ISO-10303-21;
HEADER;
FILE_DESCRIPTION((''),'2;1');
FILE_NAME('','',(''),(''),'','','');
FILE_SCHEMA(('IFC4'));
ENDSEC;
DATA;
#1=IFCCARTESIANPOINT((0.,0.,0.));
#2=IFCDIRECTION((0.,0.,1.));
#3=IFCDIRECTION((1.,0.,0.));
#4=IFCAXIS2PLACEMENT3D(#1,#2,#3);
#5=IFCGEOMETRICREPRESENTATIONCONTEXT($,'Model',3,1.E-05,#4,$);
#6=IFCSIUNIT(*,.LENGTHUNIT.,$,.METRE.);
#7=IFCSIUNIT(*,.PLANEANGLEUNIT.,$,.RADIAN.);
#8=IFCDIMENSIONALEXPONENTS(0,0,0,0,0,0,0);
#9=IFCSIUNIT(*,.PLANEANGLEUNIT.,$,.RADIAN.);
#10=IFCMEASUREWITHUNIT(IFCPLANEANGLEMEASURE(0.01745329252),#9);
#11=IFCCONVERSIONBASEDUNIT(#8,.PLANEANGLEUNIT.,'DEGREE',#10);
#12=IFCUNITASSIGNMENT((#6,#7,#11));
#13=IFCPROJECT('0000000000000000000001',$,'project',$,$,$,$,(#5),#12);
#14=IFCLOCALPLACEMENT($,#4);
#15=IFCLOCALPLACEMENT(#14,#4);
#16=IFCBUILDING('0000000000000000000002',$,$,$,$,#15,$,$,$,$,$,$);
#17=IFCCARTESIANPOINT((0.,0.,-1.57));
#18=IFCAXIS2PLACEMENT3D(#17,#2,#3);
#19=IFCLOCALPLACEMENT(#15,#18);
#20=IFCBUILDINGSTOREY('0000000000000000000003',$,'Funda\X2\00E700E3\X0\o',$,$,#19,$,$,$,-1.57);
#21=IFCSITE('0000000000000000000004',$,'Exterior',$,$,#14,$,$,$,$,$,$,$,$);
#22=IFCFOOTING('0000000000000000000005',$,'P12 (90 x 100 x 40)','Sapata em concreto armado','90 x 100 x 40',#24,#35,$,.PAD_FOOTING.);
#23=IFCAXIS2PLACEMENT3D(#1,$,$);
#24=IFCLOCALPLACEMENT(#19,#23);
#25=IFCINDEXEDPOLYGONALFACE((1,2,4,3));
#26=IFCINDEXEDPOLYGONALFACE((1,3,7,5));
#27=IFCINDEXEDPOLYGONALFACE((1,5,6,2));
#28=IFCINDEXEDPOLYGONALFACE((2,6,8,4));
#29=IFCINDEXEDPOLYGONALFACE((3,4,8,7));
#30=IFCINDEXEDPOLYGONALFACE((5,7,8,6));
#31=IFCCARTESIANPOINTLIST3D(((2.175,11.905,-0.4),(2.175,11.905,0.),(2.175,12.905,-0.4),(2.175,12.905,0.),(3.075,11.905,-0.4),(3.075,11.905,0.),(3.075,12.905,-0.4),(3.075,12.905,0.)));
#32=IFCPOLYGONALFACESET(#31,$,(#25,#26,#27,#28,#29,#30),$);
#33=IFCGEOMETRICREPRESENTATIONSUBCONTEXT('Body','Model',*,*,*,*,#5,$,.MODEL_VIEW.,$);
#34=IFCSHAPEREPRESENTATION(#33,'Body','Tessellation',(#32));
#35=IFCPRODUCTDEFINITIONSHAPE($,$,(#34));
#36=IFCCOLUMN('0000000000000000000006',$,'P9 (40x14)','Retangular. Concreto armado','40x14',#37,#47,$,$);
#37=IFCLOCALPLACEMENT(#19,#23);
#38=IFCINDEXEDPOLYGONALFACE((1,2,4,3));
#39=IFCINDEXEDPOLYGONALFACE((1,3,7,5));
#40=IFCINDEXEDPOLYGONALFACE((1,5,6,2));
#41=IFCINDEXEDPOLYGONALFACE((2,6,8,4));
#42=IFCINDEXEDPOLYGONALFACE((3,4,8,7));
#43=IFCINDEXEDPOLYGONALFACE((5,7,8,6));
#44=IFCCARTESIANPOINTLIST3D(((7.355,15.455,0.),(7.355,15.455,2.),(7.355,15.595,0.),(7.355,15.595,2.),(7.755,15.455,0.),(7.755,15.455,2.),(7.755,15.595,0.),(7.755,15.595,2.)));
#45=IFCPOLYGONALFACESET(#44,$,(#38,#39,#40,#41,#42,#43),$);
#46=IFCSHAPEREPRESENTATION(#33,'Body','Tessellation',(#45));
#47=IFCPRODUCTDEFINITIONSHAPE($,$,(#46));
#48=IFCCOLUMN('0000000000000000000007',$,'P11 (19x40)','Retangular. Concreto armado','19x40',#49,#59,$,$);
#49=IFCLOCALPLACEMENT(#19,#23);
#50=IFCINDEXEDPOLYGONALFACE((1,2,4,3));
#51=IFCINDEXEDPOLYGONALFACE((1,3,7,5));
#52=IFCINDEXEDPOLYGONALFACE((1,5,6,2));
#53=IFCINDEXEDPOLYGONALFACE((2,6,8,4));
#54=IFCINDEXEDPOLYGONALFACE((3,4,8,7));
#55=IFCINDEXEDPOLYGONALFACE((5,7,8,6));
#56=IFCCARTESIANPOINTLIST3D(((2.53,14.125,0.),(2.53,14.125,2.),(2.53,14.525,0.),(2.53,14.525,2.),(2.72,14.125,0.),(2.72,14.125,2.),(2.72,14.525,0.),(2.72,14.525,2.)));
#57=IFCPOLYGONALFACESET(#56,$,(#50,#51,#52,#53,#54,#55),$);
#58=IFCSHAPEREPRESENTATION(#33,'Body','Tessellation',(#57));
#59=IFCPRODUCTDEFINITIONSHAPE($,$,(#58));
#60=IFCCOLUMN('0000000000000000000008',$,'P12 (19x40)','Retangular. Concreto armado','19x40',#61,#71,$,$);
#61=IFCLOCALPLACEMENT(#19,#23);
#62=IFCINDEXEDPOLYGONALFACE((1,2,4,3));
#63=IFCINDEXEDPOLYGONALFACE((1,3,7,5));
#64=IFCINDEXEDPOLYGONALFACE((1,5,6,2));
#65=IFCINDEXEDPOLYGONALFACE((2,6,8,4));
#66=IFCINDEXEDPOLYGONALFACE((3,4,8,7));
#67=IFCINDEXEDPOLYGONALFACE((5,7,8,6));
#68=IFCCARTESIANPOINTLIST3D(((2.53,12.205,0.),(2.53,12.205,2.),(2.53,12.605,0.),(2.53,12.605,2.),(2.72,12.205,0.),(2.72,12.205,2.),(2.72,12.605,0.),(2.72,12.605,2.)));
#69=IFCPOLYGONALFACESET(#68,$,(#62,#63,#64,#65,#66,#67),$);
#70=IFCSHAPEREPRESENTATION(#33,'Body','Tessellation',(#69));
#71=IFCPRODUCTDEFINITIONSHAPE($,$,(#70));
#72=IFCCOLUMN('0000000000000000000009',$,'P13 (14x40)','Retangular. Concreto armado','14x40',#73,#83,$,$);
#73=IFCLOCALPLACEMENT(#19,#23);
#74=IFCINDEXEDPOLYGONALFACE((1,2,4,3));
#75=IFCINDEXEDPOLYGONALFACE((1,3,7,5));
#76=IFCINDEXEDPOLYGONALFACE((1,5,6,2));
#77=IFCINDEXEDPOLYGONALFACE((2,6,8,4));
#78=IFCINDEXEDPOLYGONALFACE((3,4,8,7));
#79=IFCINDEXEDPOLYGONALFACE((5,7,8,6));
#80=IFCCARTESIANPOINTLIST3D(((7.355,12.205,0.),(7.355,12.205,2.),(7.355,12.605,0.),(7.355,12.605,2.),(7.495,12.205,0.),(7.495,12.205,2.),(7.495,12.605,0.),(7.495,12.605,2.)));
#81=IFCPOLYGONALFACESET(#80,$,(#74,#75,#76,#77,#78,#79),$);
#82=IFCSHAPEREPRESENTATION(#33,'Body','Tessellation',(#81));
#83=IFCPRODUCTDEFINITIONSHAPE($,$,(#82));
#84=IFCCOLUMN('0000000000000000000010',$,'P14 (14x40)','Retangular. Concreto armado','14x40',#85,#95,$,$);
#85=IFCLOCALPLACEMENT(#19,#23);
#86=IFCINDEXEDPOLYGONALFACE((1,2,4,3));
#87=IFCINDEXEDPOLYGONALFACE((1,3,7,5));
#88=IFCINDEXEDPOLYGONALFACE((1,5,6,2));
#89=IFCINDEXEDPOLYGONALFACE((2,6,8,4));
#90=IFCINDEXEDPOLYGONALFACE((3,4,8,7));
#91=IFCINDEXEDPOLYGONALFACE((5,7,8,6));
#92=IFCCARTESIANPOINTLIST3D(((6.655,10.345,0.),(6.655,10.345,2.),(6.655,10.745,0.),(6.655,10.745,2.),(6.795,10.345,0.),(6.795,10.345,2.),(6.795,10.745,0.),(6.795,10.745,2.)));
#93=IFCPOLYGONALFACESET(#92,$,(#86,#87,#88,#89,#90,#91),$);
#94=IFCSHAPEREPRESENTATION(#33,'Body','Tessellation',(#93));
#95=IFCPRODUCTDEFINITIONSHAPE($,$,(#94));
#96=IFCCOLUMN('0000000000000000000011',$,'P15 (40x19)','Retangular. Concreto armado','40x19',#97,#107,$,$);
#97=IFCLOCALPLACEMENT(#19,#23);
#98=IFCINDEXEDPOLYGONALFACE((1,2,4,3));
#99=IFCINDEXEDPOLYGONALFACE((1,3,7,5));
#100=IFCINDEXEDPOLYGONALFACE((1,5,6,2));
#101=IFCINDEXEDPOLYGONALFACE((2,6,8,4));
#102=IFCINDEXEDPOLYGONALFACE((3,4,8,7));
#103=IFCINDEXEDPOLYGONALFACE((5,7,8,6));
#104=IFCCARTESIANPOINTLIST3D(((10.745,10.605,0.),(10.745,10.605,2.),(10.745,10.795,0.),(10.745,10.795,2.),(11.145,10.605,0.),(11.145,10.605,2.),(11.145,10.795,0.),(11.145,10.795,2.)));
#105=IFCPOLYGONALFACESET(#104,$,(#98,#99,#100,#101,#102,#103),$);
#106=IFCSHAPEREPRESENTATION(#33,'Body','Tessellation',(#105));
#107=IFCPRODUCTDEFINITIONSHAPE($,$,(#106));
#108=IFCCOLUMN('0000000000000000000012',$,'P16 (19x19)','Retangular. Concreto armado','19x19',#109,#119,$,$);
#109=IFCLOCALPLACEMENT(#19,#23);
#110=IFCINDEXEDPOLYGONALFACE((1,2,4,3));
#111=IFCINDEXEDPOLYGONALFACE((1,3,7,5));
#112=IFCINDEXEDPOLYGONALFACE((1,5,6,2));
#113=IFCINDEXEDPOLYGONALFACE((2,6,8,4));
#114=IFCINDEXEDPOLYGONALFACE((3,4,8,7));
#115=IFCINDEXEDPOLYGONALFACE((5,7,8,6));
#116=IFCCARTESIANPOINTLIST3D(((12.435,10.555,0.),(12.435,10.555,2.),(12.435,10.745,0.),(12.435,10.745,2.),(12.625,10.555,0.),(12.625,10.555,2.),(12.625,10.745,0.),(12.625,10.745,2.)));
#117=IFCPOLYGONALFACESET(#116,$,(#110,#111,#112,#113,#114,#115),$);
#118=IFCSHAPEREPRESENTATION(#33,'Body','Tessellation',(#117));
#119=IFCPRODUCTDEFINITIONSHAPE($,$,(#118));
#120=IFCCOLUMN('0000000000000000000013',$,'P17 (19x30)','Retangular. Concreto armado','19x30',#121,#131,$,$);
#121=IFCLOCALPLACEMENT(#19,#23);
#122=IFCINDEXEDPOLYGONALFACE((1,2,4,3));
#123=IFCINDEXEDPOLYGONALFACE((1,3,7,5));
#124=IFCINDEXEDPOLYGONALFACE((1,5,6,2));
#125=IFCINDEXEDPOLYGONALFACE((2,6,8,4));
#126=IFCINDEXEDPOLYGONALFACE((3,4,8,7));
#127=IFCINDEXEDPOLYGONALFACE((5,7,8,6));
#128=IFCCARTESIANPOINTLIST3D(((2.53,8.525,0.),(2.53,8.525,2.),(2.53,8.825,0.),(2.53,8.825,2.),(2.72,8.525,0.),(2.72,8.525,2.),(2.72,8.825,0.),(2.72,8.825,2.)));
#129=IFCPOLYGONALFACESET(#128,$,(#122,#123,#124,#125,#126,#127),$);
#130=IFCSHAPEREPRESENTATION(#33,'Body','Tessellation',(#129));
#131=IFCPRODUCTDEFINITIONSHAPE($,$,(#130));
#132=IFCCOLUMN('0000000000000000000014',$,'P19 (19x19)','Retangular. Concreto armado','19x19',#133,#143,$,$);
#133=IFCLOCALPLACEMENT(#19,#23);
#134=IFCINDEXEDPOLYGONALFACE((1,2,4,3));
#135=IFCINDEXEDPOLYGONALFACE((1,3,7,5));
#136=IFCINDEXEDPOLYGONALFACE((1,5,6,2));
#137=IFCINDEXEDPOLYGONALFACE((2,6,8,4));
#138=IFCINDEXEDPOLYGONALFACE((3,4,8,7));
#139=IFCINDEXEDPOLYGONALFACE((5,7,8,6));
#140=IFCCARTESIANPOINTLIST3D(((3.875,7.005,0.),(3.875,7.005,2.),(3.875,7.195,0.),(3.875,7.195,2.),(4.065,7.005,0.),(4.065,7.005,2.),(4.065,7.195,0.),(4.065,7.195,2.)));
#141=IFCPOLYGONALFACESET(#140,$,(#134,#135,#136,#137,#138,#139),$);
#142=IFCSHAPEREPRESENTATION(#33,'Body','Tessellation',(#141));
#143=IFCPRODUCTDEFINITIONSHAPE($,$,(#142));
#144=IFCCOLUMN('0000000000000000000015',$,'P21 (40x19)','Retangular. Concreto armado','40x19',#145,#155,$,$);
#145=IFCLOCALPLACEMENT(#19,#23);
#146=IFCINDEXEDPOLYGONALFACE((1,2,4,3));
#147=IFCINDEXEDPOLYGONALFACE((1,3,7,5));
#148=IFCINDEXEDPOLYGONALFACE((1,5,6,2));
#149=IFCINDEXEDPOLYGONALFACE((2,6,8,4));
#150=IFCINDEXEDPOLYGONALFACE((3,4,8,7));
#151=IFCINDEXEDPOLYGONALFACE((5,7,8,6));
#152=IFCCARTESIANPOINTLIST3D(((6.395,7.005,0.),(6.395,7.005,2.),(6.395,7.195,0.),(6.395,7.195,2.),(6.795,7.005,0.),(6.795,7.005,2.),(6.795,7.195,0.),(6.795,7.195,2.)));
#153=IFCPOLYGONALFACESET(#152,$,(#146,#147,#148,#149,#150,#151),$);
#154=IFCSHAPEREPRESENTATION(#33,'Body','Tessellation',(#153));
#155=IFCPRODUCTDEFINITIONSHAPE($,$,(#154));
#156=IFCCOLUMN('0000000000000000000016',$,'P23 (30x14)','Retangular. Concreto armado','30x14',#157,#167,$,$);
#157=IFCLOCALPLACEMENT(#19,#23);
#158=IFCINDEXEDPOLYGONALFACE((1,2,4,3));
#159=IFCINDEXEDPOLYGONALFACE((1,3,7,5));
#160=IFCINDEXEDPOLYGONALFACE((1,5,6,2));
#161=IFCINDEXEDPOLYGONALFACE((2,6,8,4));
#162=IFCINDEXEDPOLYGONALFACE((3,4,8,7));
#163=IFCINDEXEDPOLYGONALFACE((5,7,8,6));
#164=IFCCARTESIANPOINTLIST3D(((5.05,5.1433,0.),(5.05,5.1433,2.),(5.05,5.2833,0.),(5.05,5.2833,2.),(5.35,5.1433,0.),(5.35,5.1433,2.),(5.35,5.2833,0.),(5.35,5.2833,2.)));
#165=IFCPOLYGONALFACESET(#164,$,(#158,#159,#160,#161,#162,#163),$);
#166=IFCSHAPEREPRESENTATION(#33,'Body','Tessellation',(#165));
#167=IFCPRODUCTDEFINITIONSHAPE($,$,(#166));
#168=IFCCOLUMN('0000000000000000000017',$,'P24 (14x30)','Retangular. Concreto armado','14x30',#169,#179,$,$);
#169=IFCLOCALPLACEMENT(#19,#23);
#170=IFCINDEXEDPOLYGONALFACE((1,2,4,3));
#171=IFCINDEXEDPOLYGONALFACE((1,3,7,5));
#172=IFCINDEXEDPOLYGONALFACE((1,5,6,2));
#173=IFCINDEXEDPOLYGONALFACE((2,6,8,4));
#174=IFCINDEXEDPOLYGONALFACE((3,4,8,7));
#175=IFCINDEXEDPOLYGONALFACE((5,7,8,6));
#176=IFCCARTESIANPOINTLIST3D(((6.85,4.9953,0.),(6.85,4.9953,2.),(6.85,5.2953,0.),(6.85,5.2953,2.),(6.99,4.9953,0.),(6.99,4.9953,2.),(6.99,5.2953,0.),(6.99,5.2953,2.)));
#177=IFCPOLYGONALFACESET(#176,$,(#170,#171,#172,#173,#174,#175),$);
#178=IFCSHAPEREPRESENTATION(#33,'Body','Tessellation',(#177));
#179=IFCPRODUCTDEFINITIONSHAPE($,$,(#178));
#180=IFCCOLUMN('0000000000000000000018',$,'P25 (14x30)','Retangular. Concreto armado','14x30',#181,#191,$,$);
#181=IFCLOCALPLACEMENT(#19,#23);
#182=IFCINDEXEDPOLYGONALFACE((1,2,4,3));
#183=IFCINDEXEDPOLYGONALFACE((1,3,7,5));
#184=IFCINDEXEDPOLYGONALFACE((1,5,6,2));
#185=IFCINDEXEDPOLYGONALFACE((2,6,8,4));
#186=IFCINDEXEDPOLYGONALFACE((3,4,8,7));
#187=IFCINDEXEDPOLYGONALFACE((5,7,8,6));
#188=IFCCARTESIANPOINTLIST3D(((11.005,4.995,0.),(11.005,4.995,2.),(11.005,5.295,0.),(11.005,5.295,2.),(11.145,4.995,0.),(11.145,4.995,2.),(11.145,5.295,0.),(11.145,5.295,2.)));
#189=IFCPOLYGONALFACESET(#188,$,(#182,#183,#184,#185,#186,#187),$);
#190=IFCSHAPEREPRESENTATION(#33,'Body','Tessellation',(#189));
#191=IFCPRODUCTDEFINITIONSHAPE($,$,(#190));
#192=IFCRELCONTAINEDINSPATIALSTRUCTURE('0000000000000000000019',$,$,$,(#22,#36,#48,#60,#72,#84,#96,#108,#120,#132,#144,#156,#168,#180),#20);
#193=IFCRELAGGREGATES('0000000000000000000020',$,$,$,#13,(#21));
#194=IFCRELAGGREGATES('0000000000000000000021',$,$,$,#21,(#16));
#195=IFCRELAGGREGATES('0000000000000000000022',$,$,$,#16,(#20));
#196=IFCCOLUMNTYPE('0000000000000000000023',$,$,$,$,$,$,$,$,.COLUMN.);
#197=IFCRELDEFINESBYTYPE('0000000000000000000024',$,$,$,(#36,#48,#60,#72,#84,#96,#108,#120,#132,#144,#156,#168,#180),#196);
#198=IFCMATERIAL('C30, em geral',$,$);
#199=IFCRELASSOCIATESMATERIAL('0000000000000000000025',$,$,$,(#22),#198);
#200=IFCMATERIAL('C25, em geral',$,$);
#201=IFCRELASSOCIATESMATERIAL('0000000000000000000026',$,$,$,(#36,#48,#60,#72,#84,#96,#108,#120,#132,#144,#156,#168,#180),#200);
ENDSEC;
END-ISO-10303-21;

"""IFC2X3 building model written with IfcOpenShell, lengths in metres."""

from ifc_helpers import new_model, entity, si_unit, converted_unit, frame, frame_2d, origin_with_axes, origin_2d_with_axis, place, context, subcontext, project, spatial, rectangle, extrude, material, type_object, element, save


model = new_model("IFC2X3")

# Units and contexts
model_context = context("Model", 3, precision=1e-05, world=origin_with_axes())
body_context = subcontext(model_context, "Body", "Model", "MODEL_VIEW")
ifc_project = project(units=[si_unit("LENGTHUNIT", "METRE"), si_unit("PLANEANGLEUNIT", "RADIAN"), converted_unit("PLANEANGLEUNIT", "DEGREE", entity("IfcPlaneAngleMeasure", 0.01745329252), si_unit("PLANEANGLEUNIT", "RADIAN"), dimensions=[0, 0, 0, 0, 0, 0, 0])], contexts=[model_context])

# Site, building, storey
site_placement = place(None, origin_with_axes())
site = spatial("IfcSite", under=ifc_project, at=site_placement, Name="Exterior")
building_placement = place(site_placement, origin_with_axes())
building = spatial("IfcBuilding", under=site, at=building_placement)
storey_placement = place(building_placement, frame((0.0, 0.0, -1.57), z_axis=(0.0, 0.0, 1.0), x_axis=(1.0, 0.0, 0.0)))
storey = spatial("IfcBuildingStorey", under=building, at=storey_placement, Name="Fundação", Elevation=-1.57)

# Footing
ifc_material_1 = material(Name="C30, em geral")
footing_1_placement = place(storey_placement, frame((2.625, 12.405, -0.4), z_axis=(0.0, 0.0, 1.0), x_axis=(1.0, 0.0, 0.0)))
element("IfcFooting", 1, at=footing_1_placement, inside=storey, material=ifc_material_1, Name="P12 (90 x 100 x 40)", Description="Sapata em concreto armado", ObjectType="90 x 100 x 40", PredefinedType="PAD_FOOTING", context=body_context, shape_type="SweptSolid", body=[
    extrude(rectangle(XDim=0.9, YDim=1.0, at=origin_2d_with_axis()), origin_with_axes(), (0.0, 0.0, 1.0), 0.4),
])

# Columns
ifc_material_2 = material(Name="C25, em geral")
column_type = type_object("IfcColumnType", PredefinedType="COLUMN")
column_1_placement = place(storey_placement, frame((7.355, 15.455, 0.0), z_axis=(0.0, 0.0, 1.0), x_axis=(1.0, 0.0, 0.0)))
element("IfcColumn", 2, at=column_1_placement, inside=storey, type_object=column_type, material=ifc_material_2, Name="P9 (40x14)", Description="Retangular. Concreto armado", ObjectType="40x14", context=body_context, shape_type="SweptSolid", body=[
    extrude(rectangle(XDim=0.4, YDim=0.14, at=frame_2d((0.2, 0.07), x_axis=(1.0, 0.0))), origin_with_axes(), (0.0, 0.0, 1.0), 2.0),
])
column_2_placement = place(storey_placement, frame((2.53, 14.525, 0.0), z_axis=(0.0, 0.0, 1.0), x_axis=(1.0, 0.0, 0.0)))
element("IfcColumn", 3, at=column_2_placement, inside=storey, type_object=column_type, material=ifc_material_2, Name="P11 (19x40)", Description="Retangular. Concreto armado", ObjectType="19x40", context=body_context, shape_type="SweptSolid", body=[
    extrude(rectangle(XDim=0.19, YDim=0.4, at=frame_2d((0.095, -0.2), x_axis=(1.0, 0.0))), origin_with_axes(), (0.0, 0.0, 1.0), 2.0),
])
column_3_placement = place(storey_placement, frame((2.53, 12.205, 0.0), z_axis=(0.0, 0.0, 1.0), x_axis=(1.0, 0.0, 0.0)))
element("IfcColumn", 4, at=column_3_placement, inside=storey, type_object=column_type, material=ifc_material_2, Name="P12 (19x40)", Description="Retangular. Concreto armado", ObjectType="19x40", context=body_context, shape_type="SweptSolid", body=[
    extrude(rectangle(XDim=0.19, YDim=0.4, at=frame_2d((0.095, 0.2), x_axis=(1.0, 0.0))), origin_with_axes(), (0.0, 0.0, 1.0), 2.0),
])
column_4_placement = place(storey_placement, frame((7.495, 12.205, 0.0), z_axis=(0.0, 0.0, 1.0), x_axis=(1.0, 0.0, 0.0)))
element("IfcColumn", 5, at=column_4_placement, inside=storey, type_object=column_type, material=ifc_material_2, Name="P13 (14x40)", Description="Retangular. Concreto armado", ObjectType="14x40", context=body_context, shape_type="SweptSolid", body=[
    extrude(rectangle(XDim=0.14, YDim=0.4, at=frame_2d((-0.07, 0.2), x_axis=(1.0, 0.0))), origin_with_axes(), (0.0, 0.0, 1.0), 2.0),
])
column_5_placement = place(storey_placement, frame((6.655, 10.745, 0.0), z_axis=(0.0, 0.0, 1.0), x_axis=(1.0, 0.0, 0.0)))
element("IfcColumn", 6, at=column_5_placement, inside=storey, type_object=column_type, material=ifc_material_2, Name="P14 (14x40)", Description="Retangular. Concreto armado", ObjectType="14x40", context=body_context, shape_type="SweptSolid", body=[
    extrude(rectangle(XDim=0.14, YDim=0.4, at=frame_2d((0.07, -0.2), x_axis=(1.0, 0.0))), origin_with_axes(), (0.0, 0.0, 1.0), 2.0),
])
column_6_placement = place(storey_placement, frame((11.145, 10.605, 0.0), z_axis=(0.0, 0.0, 1.0), x_axis=(1.0, 0.0, 0.0)))
element("IfcColumn", 7, at=column_6_placement, inside=storey, type_object=column_type, material=ifc_material_2, Name="P15 (40x19)", Description="Retangular. Concreto armado", ObjectType="40x19", context=body_context, shape_type="SweptSolid", body=[
    extrude(rectangle(XDim=0.4, YDim=0.19, at=frame_2d((-0.2, 0.095), x_axis=(1.0, 0.0))), origin_with_axes(), (0.0, 0.0, 1.0), 2.0),
])
column_7_placement = place(storey_placement, frame((12.625, 10.745, 0.0), z_axis=(0.0, 0.0, 1.0), x_axis=(1.0, 0.0, 0.0)))
element("IfcColumn", 8, at=column_7_placement, inside=storey, type_object=column_type, material=ifc_material_2, Name="P16 (19x19)", Description="Retangular. Concreto armado", ObjectType="19x19", context=body_context, shape_type="SweptSolid", body=[
    extrude(rectangle(XDim=0.19, YDim=0.19, at=frame_2d((-0.095, -0.095), x_axis=(1.0, 0.0))), origin_with_axes(), (0.0, 0.0, 1.0), 2.0),
])
column_8_placement = place(storey_placement, frame((2.53, 8.525, 0.0), z_axis=(0.0, 0.0, 1.0), x_axis=(1.0, 0.0, 0.0)))
element("IfcColumn", 9, at=column_8_placement, inside=storey, type_object=column_type, material=ifc_material_2, Name="P17 (19x30)", Description="Retangular. Concreto armado", ObjectType="19x30", context=body_context, shape_type="SweptSolid", body=[
    extrude(rectangle(XDim=0.19, YDim=0.3, at=frame_2d((0.095, 0.15), x_axis=(1.0, 0.0))), origin_with_axes(), (0.0, 0.0, 1.0), 2.0),
])
column_9_placement = place(storey_placement, frame((3.875, 7.005, 0.0), z_axis=(0.0, 0.0, 1.0), x_axis=(1.0, 0.0, 0.0)))
element("IfcColumn", 10, at=column_9_placement, inside=storey, type_object=column_type, material=ifc_material_2, Name="P19 (19x19)", Description="Retangular. Concreto armado", ObjectType="19x19", context=body_context, shape_type="SweptSolid", body=[
    extrude(rectangle(XDim=0.19, YDim=0.19, at=frame_2d((0.095, 0.095), x_axis=(1.0, 0.0))), origin_with_axes(), (0.0, 0.0, 1.0), 2.0),
])
column_10_placement = place(storey_placement, frame((6.795, 7.005, 0.0), z_axis=(0.0, 0.0, 1.0), x_axis=(1.0, 0.0, 0.0)))
element("IfcColumn", 11, at=column_10_placement, inside=storey, type_object=column_type, material=ifc_material_2, Name="P21 (40x19)", Description="Retangular. Concreto armado", ObjectType="40x19", context=body_context, shape_type="SweptSolid", body=[
    extrude(rectangle(XDim=0.4, YDim=0.19, at=frame_2d((-0.2, 0.095), x_axis=(1.0, 0.0))), origin_with_axes(), (0.0, 0.0, 1.0), 2.0),
])
column_11_placement = place(storey_placement, frame((5.05, 5.1433, 0.0), z_axis=(0.0, 0.0, 1.0), x_axis=(1.0, 0.0, 0.0)))
element("IfcColumn", 12, at=column_11_placement, inside=storey, type_object=column_type, material=ifc_material_2, Name="P23 (30x14)", Description="Retangular. Concreto armado", ObjectType="30x14", context=body_context, shape_type="SweptSolid", body=[
    extrude(rectangle(XDim=0.3, YDim=0.14, at=frame_2d((0.15, 0.07), x_axis=(1.0, 0.0))), origin_with_axes(), (0.0, 0.0, 1.0), 2.0),
])
column_12_placement = place(storey_placement, frame((6.85, 4.9953, 0.0), z_axis=(0.0, 0.0, 1.0), x_axis=(1.0, 0.0, 0.0)))
element("IfcColumn", 13, at=column_12_placement, inside=storey, type_object=column_type, material=ifc_material_2, Name="P24 (14x30)", Description="Retangular. Concreto armado", ObjectType="14x30", context=body_context, shape_type="SweptSolid", body=[
    extrude(rectangle(XDim=0.14, YDim=0.3, at=frame_2d((0.07, 0.15), x_axis=(1.0, 0.0))), origin_with_axes(), (0.0, 0.0, 1.0), 2.0),
])
column_13_placement = place(storey_placement, frame((11.145, 5.145, 0.0), z_axis=(0.0, 0.0, 1.0), x_axis=(1.0, 0.0, 0.0)))
element("IfcColumn", 14, at=column_13_placement, inside=storey, type_object=column_type, material=ifc_material_2, Name="P25 (14x30)", Description="Retangular. Concreto armado", ObjectType="14x30", context=body_context, shape_type="SweptSolid", body=[
    extrude(rectangle(XDim=0.14, YDim=0.3, at=frame_2d((-0.07, 0.0), x_axis=(1.0, 0.0))), origin_with_axes(), (0.0, 0.0, 1.0), 2.0),
])

save(model, "model.ifc")
